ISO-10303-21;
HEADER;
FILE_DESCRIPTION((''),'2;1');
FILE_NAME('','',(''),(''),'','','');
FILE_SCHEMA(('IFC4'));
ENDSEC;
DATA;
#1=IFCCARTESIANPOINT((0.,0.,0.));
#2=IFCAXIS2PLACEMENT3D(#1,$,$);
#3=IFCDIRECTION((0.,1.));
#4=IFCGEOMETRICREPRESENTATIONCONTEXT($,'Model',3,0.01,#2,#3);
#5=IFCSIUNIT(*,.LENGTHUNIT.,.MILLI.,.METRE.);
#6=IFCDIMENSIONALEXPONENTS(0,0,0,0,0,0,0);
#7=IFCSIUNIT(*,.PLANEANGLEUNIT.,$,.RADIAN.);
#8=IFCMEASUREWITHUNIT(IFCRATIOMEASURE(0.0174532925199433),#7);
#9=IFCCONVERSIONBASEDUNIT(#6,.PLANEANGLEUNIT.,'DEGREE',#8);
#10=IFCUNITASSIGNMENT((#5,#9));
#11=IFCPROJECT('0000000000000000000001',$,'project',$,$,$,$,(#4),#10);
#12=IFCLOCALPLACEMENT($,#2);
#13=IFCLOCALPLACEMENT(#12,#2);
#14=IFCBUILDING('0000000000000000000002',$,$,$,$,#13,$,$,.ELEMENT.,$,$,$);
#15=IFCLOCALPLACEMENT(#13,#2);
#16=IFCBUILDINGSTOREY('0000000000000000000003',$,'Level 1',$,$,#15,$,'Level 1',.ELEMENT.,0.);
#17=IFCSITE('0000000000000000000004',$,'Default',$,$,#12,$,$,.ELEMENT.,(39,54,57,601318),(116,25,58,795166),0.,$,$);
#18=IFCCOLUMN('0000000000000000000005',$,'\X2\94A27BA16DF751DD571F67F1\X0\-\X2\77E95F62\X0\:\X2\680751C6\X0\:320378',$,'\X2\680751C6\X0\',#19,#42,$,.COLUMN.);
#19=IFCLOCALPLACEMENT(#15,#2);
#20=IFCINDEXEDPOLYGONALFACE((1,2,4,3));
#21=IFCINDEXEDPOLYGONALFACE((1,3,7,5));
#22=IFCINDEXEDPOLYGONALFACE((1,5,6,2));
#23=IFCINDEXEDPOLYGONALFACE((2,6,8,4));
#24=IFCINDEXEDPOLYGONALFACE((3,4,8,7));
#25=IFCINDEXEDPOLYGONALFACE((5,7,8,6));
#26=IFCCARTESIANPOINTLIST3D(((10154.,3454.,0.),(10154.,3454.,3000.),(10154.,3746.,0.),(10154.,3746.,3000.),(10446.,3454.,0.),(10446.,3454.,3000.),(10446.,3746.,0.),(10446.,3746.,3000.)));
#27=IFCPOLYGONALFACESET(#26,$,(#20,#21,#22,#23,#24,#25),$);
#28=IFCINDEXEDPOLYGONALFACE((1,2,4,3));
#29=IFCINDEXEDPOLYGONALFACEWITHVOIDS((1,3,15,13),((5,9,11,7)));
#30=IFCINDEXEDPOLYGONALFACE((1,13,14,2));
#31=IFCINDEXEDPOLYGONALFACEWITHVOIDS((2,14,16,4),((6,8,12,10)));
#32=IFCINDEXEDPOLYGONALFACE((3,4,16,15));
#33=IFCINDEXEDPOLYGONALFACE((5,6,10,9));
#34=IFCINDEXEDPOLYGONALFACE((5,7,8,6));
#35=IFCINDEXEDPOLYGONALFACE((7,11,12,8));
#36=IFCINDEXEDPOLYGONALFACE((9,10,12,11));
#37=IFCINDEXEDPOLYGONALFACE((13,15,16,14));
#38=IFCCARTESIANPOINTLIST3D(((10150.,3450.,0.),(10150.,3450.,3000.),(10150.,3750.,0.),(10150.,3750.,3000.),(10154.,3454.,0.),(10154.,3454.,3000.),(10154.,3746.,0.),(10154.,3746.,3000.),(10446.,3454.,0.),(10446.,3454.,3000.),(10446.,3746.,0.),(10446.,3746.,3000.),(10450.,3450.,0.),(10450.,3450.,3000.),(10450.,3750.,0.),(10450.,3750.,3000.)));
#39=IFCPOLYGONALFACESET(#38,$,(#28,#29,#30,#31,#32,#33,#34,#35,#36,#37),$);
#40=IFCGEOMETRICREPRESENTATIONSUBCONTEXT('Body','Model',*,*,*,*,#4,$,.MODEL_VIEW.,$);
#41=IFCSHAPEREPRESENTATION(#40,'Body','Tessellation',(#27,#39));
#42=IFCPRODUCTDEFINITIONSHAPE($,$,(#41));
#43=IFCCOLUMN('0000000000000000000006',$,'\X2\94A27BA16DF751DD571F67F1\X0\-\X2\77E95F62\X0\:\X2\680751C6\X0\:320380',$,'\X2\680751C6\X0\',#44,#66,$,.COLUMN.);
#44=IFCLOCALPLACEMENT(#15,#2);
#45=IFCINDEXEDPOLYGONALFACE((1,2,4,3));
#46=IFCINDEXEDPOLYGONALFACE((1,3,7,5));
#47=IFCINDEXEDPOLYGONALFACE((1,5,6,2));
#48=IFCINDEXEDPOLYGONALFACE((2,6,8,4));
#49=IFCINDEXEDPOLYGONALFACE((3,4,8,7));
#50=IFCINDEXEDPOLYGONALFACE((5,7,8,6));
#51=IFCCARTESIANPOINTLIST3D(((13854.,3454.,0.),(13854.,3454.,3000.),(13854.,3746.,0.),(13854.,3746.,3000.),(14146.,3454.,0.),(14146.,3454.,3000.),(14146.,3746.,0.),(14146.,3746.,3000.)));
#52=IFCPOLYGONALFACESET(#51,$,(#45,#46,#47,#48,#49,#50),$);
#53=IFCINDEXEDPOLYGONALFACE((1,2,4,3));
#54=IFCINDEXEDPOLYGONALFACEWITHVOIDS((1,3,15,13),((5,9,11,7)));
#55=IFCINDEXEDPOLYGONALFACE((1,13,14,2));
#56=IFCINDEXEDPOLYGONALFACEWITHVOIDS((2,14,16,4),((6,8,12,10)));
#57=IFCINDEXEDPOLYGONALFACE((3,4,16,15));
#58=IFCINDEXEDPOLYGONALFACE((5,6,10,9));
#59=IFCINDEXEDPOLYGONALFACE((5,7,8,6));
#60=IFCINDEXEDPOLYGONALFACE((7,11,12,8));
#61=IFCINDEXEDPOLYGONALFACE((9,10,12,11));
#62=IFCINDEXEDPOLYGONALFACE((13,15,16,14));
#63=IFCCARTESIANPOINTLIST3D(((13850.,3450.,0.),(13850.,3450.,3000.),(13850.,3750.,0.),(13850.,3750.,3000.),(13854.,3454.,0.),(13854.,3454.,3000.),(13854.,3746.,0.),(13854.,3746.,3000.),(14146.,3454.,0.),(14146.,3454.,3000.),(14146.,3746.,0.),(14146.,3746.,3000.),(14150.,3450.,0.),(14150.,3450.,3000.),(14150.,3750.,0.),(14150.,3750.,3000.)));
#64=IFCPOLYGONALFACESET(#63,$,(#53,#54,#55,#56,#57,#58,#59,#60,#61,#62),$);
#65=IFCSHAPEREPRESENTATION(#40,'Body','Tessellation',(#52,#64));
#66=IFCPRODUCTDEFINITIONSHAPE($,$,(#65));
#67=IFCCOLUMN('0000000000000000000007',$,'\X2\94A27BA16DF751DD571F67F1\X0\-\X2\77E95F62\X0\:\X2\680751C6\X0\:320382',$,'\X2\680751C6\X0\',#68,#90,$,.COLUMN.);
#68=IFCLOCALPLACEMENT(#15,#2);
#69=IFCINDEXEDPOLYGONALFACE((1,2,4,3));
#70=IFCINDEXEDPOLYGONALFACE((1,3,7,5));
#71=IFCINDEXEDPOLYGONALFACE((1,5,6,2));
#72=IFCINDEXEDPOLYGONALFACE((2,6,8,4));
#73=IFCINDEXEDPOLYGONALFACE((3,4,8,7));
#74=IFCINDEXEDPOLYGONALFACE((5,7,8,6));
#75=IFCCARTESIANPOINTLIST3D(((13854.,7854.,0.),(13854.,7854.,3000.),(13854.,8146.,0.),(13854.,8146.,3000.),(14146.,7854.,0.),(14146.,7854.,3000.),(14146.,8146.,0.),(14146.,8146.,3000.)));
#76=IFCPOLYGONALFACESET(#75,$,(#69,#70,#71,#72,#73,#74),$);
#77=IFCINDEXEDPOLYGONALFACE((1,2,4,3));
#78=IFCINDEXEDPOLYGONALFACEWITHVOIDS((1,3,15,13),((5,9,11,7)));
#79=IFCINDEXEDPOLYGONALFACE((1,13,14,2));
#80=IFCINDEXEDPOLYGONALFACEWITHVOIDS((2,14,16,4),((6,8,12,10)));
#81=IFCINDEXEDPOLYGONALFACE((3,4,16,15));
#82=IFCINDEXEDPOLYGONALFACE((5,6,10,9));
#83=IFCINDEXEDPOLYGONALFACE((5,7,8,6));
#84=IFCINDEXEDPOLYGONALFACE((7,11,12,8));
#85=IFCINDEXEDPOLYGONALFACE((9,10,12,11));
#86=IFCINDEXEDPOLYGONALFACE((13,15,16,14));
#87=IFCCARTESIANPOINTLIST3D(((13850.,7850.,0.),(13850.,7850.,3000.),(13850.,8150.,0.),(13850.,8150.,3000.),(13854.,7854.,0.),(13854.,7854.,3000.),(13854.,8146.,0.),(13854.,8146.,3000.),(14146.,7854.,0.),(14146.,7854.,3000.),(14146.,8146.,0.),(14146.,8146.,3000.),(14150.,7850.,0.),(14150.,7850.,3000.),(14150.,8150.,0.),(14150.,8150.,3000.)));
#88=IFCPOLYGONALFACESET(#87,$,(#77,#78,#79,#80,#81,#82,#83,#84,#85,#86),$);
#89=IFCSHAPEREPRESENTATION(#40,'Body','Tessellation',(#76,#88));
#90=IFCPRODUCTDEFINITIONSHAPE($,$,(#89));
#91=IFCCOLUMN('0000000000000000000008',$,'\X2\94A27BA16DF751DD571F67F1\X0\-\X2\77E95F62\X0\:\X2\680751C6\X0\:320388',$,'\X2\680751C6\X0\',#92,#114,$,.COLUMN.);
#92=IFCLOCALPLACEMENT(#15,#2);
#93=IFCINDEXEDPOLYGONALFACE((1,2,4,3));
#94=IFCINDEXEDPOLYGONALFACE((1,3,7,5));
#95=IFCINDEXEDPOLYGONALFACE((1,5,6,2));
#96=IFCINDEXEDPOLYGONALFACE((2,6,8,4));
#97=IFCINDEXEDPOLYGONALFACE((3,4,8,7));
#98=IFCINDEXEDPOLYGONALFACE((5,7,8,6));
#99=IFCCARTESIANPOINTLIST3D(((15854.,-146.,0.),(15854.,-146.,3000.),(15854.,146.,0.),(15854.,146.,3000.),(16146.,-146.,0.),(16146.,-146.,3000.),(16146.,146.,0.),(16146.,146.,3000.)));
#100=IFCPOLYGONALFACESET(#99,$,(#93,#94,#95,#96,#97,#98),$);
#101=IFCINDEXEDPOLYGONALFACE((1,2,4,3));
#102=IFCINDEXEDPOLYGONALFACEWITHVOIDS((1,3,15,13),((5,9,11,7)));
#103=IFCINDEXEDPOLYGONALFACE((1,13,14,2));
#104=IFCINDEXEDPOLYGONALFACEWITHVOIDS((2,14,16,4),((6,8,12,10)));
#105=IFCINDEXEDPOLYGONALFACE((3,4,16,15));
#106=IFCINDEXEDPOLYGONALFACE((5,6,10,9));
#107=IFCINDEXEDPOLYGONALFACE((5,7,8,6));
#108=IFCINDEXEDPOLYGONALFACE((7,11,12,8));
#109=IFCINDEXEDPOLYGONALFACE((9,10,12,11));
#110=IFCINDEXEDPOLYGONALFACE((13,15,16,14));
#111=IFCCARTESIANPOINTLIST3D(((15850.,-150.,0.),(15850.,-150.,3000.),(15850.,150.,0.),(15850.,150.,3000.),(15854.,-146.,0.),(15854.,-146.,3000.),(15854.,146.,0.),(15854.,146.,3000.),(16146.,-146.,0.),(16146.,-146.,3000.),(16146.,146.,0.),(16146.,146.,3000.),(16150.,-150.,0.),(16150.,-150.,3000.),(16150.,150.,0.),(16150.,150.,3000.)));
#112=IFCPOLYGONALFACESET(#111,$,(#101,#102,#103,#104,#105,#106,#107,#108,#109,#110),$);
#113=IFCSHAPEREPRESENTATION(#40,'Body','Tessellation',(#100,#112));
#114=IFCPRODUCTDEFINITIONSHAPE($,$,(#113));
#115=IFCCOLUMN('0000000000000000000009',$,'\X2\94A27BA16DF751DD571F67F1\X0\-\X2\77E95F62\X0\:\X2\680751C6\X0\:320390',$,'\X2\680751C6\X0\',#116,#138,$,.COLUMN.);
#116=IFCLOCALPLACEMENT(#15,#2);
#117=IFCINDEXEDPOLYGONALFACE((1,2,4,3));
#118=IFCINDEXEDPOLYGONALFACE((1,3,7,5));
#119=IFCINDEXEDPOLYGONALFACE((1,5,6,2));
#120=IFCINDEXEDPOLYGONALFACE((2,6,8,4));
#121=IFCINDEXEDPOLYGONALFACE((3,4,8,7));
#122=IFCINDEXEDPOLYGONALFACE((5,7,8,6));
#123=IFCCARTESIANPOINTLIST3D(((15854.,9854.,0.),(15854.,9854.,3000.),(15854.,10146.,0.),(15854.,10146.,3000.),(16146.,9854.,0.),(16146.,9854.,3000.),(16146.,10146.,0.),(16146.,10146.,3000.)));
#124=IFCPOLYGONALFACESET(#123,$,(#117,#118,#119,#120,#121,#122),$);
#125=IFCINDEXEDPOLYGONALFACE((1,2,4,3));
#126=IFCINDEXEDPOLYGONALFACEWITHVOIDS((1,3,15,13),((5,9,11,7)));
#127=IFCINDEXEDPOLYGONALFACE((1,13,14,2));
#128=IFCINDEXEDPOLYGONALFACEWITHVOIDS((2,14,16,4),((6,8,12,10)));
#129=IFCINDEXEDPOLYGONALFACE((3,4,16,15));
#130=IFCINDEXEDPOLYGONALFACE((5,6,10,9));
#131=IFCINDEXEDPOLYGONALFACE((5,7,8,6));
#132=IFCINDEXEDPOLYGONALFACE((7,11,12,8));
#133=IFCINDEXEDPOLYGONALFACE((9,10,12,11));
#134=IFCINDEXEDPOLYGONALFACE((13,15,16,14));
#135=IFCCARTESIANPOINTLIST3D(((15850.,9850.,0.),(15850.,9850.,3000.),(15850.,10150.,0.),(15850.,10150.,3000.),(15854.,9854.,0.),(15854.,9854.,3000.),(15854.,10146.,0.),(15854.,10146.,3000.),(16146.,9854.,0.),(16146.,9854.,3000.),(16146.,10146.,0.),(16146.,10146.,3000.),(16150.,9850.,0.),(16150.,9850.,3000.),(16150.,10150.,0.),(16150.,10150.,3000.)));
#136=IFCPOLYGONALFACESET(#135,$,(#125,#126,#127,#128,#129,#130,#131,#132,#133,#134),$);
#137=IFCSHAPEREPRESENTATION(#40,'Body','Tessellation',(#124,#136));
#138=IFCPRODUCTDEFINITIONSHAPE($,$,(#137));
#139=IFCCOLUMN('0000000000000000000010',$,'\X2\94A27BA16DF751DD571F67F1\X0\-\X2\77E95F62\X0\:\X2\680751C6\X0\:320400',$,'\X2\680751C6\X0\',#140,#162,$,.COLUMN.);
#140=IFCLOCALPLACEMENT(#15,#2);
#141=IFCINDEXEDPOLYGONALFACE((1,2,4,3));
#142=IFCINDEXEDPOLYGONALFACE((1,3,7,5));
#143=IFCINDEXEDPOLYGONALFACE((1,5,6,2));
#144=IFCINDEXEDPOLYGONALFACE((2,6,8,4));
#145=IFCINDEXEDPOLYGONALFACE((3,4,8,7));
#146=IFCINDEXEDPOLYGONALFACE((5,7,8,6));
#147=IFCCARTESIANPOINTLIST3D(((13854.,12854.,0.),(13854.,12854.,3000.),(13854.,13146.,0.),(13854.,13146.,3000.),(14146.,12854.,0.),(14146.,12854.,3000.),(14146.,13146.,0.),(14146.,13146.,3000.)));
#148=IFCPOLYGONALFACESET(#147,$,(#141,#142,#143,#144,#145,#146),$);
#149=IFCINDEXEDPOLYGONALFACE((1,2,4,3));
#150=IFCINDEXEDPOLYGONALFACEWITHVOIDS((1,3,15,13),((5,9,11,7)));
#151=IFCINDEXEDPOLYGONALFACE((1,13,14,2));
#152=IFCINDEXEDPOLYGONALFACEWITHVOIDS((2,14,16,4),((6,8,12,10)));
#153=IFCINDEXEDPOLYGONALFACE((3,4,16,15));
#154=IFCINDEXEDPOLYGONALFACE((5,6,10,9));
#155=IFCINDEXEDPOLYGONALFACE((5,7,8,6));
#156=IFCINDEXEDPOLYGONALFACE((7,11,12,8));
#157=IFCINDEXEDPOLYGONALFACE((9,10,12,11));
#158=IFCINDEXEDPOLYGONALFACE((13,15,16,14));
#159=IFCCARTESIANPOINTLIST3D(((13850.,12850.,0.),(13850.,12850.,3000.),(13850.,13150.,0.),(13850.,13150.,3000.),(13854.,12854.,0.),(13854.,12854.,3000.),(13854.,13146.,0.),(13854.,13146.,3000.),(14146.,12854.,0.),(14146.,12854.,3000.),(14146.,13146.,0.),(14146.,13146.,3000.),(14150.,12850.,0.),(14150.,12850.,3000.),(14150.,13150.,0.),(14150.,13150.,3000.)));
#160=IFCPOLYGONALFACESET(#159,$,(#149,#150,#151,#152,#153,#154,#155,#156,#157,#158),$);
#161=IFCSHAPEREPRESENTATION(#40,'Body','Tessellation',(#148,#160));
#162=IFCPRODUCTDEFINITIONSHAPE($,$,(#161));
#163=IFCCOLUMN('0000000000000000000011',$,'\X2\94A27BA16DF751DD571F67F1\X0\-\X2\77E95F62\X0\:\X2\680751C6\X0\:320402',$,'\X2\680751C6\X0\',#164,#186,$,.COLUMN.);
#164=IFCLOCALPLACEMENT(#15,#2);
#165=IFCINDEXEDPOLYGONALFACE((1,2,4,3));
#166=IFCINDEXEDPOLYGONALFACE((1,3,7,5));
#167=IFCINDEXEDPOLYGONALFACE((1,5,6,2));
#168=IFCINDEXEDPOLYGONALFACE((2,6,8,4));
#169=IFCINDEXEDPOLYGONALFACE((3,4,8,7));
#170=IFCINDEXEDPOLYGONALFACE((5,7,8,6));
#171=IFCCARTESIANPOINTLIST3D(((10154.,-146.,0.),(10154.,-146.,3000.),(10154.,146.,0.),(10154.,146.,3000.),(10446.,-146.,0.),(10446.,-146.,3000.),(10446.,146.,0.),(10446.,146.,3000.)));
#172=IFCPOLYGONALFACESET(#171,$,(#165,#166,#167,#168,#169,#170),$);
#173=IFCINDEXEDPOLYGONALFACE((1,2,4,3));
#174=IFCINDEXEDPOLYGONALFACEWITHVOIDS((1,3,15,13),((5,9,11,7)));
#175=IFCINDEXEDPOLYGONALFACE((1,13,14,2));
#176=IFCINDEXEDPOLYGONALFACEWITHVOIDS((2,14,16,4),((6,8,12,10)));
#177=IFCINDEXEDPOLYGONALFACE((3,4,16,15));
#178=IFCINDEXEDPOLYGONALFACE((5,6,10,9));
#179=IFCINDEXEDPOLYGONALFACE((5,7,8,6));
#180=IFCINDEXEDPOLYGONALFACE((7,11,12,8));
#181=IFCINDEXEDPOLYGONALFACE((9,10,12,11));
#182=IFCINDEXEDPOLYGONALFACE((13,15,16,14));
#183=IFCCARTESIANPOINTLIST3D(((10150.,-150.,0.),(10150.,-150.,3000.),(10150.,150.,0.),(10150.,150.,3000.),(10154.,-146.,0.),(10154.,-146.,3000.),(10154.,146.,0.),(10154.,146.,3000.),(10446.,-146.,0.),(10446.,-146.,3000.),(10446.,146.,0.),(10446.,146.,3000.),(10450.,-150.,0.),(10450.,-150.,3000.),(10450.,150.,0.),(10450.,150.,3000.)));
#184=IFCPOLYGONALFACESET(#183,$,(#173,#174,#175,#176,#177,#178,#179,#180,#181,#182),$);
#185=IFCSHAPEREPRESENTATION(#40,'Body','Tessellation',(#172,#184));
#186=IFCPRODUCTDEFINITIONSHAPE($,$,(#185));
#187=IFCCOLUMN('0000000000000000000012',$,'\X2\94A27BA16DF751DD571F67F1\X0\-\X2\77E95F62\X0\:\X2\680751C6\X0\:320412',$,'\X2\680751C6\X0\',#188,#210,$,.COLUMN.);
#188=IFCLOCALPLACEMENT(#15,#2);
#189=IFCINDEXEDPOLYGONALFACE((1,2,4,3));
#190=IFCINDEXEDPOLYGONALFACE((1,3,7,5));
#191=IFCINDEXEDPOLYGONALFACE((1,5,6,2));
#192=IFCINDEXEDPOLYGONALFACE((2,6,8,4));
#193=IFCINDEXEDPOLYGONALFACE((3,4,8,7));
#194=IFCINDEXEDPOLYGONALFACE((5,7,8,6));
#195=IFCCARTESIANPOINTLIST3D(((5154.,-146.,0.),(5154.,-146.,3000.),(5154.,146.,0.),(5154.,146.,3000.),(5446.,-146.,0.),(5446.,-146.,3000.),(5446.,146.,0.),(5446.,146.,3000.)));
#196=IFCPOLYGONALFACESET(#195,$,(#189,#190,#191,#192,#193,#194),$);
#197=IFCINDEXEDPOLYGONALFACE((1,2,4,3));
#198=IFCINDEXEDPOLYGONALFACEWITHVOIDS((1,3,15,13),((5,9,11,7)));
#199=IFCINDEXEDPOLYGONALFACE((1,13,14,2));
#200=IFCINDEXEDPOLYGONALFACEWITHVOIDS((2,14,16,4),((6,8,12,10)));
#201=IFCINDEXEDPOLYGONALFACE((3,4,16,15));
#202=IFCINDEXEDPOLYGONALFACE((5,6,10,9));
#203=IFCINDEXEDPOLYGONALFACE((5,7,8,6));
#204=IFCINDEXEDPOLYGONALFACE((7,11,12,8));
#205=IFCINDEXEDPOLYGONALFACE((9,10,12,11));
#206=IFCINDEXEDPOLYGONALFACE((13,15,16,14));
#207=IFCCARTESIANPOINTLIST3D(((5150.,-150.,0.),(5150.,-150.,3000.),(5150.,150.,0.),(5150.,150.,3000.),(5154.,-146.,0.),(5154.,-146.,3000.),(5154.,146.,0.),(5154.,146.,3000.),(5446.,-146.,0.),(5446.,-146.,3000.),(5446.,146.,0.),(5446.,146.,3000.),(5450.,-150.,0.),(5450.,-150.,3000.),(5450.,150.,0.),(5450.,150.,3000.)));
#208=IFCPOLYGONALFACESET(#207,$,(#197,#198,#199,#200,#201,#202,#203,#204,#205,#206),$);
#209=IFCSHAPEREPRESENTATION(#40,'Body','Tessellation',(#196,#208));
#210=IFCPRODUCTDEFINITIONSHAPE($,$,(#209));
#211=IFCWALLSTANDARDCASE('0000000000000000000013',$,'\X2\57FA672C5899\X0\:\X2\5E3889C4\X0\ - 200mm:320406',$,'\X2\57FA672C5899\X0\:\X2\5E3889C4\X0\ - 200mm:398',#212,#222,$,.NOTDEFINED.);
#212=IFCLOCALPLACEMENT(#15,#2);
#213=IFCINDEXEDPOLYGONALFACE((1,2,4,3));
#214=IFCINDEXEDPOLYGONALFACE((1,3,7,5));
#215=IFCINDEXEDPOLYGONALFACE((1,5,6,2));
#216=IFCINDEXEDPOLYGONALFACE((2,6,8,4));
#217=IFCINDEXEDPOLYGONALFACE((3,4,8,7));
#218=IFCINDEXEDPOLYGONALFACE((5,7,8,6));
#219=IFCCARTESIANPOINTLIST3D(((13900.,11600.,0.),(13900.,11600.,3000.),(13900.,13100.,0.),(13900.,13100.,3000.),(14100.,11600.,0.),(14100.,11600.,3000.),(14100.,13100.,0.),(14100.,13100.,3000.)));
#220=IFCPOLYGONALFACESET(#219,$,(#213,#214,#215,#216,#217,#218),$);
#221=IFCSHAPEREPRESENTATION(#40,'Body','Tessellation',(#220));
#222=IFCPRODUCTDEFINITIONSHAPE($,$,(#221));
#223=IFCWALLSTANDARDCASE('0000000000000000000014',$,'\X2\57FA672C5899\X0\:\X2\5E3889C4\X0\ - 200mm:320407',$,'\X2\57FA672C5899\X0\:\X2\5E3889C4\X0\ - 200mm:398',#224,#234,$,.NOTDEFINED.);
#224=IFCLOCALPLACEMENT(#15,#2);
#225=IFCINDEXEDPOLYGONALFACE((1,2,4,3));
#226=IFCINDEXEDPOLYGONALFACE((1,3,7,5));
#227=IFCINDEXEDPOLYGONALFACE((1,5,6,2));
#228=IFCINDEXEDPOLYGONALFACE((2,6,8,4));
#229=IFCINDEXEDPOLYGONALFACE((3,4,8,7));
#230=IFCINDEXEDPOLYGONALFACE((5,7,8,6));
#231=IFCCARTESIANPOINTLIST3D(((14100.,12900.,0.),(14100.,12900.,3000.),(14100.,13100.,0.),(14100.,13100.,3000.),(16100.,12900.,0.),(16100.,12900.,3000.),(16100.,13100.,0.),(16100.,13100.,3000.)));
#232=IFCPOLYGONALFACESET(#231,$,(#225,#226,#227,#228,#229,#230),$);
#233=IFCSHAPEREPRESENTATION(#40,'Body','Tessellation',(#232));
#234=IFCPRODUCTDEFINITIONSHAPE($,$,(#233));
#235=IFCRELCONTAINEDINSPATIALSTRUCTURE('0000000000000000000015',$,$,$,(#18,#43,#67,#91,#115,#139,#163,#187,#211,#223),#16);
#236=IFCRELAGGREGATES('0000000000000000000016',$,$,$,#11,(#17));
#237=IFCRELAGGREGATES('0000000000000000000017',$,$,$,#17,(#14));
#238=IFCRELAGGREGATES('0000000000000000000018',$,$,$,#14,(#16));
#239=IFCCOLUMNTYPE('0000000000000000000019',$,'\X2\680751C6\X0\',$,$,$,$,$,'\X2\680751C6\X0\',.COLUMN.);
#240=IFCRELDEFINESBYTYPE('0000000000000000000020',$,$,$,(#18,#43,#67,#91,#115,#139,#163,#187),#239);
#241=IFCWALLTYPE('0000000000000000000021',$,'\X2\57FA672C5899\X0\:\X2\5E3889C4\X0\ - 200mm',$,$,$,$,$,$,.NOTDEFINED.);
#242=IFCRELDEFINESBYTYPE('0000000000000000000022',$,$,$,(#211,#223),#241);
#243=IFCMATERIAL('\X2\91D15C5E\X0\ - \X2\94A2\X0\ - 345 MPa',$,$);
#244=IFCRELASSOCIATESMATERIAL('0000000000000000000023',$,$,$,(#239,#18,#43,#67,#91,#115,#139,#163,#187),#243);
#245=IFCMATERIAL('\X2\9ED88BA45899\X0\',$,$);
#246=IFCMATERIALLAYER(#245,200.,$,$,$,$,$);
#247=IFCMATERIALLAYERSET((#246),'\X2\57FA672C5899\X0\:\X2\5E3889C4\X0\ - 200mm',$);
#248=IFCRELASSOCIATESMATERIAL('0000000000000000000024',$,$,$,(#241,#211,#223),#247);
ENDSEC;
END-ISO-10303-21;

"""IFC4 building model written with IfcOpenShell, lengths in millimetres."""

from ifc_helpers import new_model, entity, si_unit, converted_unit, direction, frame, frame_2d, origin, origin_2d_with_axis, place, context, subcontext, project, spatial, polyline, rectangle, outline, extrude, source, transform, mapped, material, layer, layer_set, layer_usage, type_object, type_shapes, element, save


model = new_model("IFC4")

# Units and contexts
model_context = context("Model", 3, precision=0.01, world=origin(), true_north=direction((0.0, 1.0)))
body_context = subcontext(model_context, "Body", "Model", "MODEL_VIEW")
ifc_project = project(units=[si_unit("LENGTHUNIT", "METRE", prefix="MILLI"), converted_unit("PLANEANGLEUNIT", "DEGREE", entity("IfcRatioMeasure", 0.0174532925199433), si_unit("PLANEANGLEUNIT", "RADIAN"), dimensions=[0, 0, 0, 0, 0, 0, 0])], contexts=[model_context])

# Site, building, storey
site_placement = place(None, origin())
site = spatial("IfcSite", under=ifc_project, at=site_placement, Name="Default", CompositionType="ELEMENT", RefLatitude=(39, 54, 57, 601318), RefLongitude=(116, 25, 58, 795166), RefElevation=0.0)
building_placement = place(site_placement, origin())
building = spatial("IfcBuilding", under=site, at=building_placement, CompositionType="ELEMENT")
storey_placement = place(building_placement, origin())
storey = spatial("IfcBuildingStorey", under=building, at=storey_placement, Name="Level 1", LongName="Level 1", CompositionType="ELEMENT", Elevation=0.0)

# Columns
ifc_material_1 = material(Name="金属 - 钢 - 345 MPa")
column_type = type_object("IfcColumnType", Name="标准", ElementType="标准", PredefinedType="COLUMN", material=ifc_material_1)
shared_shape_1 = source(origin(), body_context, "Body", "SweptSolid", [
    extrude(rectangle(XDim=292.0, YDim=292.0, at=origin_2d_with_axis()), frame((0.0, 0.0, 0.0), z_axis=(0.0, 0.0, 1.0), x_axis=(-1.0, 0.0, 0.0)), (0.0, 0.0, 1.0), 3000.0),
    extrude(outline(polyline([(-150.0, -150.0), (150.0, -150.0), (150.0, 150.0), (-150.0, 150.0), (-150.0, -150.0)]), holes=[polyline([(-146.0, -146.0), (-146.0, 146.0), (146.0, 146.0), (146.0, -146.0), (-146.0, -146.0)])]), frame((0.0, 0.0, 0.0), z_axis=(0.0, 0.0, 1.0), x_axis=(-1.0, 0.0, 0.0)), (0.0, 0.0, 1.0), 3000.0),
])
type_shapes(column_type, [shared_shape_1])
for number, where, name in (
    (1, (10300.0, 3600.0, 0.0), "钢管混凝土柱-矩形:标准:320378"),
    (2, (14000.0, 3600.0, 0.0), "钢管混凝土柱-矩形:标准:320380"),
    (3, (14000.0, 8000.0, 0.0), "钢管混凝土柱-矩形:标准:320382"),
    (4, (16000.0, 0.0, 0.0), "钢管混凝土柱-矩形:标准:320388"),
    (5, (16000.0, 10000.0, 0.0), "钢管混凝土柱-矩形:标准:320390"),
    (6, (14000.0, 13000.0, 0.0), "钢管混凝土柱-矩形:标准:320400"),
    (7, (10300.0, 0.0, 0.0), "钢管混凝土柱-矩形:标准:320402"),
    (8, (5300.0, 0.0, 0.0), "钢管混凝土柱-矩形:标准:320412"),
):
    element("IfcColumn", number, at=place(storey_placement, frame(where)), inside=storey, type_object=column_type, material=ifc_material_1, Name=name, ObjectType="标准", PredefinedType="COLUMN", context=body_context, shape_type="MappedRepresentation", body=[
        mapped(shared_shape_1, transform((0.0, 0.0, 0.0), scale=1.0)),
    ])

# Shared definitions
ifc_material_2 = material(Name="默认墙")
ifc_layer = layer(ifc_material_2, 200.0)
ifc_layer_set = layer_set([ifc_layer], Name="基本墙:常规 - 200mm")
wall_type = type_object("IfcWallType", Name="基本墙:常规 - 200mm", PredefinedType="NOTDEFINED", material=ifc_layer_set)

# Walls
ifc_layer_usage_1 = layer_usage(ifc_layer_set, "AXIS2", "NEGATIVE", 100.0)
wall_1_placement = place(storey_placement, frame((14000.0, 11600.0, 0.0), z_axis=(0.0, 0.0, 1.0), x_axis=(0.0, 1.0, 0.0)))
element("IfcWallStandardCase", 9, at=wall_1_placement, inside=storey, type_object=wall_type, material=ifc_layer_usage_1, Name="基本墙:常规 - 200mm:320406", ObjectType="基本墙:常规 - 200mm:398", PredefinedType="NOTDEFINED", context=body_context, shape_type="SweptSolid", body=[
    extrude(rectangle(XDim=1500.0, YDim=200.0, at=frame_2d((750.0, 0.0), x_axis=(-1.0, 0.0))), origin(), (0.0, 0.0, 1.0), 3000.0),
])
ifc_layer_usage_2 = layer_usage(ifc_layer_set, "AXIS2", "NEGATIVE", 100.0)
wall_2_placement = place(storey_placement, frame((14100.0, 13000.0, 0.0)))
element("IfcWallStandardCase", 10, at=wall_2_placement, inside=storey, type_object=wall_type, material=ifc_layer_usage_2, Name="基本墙:常规 - 200mm:320407", ObjectType="基本墙:常规 - 200mm:398", PredefinedType="NOTDEFINED", context=body_context, shape_type="SweptSolid", body=[
    extrude(rectangle(XDim=2000.0, YDim=200.0, at=frame_2d((1000.0, 0.0), x_axis=(-1.0, 0.0))), origin(), (0.0, 0.0, 1.0), 3000.0),
])

save(model, "model.ifc")
